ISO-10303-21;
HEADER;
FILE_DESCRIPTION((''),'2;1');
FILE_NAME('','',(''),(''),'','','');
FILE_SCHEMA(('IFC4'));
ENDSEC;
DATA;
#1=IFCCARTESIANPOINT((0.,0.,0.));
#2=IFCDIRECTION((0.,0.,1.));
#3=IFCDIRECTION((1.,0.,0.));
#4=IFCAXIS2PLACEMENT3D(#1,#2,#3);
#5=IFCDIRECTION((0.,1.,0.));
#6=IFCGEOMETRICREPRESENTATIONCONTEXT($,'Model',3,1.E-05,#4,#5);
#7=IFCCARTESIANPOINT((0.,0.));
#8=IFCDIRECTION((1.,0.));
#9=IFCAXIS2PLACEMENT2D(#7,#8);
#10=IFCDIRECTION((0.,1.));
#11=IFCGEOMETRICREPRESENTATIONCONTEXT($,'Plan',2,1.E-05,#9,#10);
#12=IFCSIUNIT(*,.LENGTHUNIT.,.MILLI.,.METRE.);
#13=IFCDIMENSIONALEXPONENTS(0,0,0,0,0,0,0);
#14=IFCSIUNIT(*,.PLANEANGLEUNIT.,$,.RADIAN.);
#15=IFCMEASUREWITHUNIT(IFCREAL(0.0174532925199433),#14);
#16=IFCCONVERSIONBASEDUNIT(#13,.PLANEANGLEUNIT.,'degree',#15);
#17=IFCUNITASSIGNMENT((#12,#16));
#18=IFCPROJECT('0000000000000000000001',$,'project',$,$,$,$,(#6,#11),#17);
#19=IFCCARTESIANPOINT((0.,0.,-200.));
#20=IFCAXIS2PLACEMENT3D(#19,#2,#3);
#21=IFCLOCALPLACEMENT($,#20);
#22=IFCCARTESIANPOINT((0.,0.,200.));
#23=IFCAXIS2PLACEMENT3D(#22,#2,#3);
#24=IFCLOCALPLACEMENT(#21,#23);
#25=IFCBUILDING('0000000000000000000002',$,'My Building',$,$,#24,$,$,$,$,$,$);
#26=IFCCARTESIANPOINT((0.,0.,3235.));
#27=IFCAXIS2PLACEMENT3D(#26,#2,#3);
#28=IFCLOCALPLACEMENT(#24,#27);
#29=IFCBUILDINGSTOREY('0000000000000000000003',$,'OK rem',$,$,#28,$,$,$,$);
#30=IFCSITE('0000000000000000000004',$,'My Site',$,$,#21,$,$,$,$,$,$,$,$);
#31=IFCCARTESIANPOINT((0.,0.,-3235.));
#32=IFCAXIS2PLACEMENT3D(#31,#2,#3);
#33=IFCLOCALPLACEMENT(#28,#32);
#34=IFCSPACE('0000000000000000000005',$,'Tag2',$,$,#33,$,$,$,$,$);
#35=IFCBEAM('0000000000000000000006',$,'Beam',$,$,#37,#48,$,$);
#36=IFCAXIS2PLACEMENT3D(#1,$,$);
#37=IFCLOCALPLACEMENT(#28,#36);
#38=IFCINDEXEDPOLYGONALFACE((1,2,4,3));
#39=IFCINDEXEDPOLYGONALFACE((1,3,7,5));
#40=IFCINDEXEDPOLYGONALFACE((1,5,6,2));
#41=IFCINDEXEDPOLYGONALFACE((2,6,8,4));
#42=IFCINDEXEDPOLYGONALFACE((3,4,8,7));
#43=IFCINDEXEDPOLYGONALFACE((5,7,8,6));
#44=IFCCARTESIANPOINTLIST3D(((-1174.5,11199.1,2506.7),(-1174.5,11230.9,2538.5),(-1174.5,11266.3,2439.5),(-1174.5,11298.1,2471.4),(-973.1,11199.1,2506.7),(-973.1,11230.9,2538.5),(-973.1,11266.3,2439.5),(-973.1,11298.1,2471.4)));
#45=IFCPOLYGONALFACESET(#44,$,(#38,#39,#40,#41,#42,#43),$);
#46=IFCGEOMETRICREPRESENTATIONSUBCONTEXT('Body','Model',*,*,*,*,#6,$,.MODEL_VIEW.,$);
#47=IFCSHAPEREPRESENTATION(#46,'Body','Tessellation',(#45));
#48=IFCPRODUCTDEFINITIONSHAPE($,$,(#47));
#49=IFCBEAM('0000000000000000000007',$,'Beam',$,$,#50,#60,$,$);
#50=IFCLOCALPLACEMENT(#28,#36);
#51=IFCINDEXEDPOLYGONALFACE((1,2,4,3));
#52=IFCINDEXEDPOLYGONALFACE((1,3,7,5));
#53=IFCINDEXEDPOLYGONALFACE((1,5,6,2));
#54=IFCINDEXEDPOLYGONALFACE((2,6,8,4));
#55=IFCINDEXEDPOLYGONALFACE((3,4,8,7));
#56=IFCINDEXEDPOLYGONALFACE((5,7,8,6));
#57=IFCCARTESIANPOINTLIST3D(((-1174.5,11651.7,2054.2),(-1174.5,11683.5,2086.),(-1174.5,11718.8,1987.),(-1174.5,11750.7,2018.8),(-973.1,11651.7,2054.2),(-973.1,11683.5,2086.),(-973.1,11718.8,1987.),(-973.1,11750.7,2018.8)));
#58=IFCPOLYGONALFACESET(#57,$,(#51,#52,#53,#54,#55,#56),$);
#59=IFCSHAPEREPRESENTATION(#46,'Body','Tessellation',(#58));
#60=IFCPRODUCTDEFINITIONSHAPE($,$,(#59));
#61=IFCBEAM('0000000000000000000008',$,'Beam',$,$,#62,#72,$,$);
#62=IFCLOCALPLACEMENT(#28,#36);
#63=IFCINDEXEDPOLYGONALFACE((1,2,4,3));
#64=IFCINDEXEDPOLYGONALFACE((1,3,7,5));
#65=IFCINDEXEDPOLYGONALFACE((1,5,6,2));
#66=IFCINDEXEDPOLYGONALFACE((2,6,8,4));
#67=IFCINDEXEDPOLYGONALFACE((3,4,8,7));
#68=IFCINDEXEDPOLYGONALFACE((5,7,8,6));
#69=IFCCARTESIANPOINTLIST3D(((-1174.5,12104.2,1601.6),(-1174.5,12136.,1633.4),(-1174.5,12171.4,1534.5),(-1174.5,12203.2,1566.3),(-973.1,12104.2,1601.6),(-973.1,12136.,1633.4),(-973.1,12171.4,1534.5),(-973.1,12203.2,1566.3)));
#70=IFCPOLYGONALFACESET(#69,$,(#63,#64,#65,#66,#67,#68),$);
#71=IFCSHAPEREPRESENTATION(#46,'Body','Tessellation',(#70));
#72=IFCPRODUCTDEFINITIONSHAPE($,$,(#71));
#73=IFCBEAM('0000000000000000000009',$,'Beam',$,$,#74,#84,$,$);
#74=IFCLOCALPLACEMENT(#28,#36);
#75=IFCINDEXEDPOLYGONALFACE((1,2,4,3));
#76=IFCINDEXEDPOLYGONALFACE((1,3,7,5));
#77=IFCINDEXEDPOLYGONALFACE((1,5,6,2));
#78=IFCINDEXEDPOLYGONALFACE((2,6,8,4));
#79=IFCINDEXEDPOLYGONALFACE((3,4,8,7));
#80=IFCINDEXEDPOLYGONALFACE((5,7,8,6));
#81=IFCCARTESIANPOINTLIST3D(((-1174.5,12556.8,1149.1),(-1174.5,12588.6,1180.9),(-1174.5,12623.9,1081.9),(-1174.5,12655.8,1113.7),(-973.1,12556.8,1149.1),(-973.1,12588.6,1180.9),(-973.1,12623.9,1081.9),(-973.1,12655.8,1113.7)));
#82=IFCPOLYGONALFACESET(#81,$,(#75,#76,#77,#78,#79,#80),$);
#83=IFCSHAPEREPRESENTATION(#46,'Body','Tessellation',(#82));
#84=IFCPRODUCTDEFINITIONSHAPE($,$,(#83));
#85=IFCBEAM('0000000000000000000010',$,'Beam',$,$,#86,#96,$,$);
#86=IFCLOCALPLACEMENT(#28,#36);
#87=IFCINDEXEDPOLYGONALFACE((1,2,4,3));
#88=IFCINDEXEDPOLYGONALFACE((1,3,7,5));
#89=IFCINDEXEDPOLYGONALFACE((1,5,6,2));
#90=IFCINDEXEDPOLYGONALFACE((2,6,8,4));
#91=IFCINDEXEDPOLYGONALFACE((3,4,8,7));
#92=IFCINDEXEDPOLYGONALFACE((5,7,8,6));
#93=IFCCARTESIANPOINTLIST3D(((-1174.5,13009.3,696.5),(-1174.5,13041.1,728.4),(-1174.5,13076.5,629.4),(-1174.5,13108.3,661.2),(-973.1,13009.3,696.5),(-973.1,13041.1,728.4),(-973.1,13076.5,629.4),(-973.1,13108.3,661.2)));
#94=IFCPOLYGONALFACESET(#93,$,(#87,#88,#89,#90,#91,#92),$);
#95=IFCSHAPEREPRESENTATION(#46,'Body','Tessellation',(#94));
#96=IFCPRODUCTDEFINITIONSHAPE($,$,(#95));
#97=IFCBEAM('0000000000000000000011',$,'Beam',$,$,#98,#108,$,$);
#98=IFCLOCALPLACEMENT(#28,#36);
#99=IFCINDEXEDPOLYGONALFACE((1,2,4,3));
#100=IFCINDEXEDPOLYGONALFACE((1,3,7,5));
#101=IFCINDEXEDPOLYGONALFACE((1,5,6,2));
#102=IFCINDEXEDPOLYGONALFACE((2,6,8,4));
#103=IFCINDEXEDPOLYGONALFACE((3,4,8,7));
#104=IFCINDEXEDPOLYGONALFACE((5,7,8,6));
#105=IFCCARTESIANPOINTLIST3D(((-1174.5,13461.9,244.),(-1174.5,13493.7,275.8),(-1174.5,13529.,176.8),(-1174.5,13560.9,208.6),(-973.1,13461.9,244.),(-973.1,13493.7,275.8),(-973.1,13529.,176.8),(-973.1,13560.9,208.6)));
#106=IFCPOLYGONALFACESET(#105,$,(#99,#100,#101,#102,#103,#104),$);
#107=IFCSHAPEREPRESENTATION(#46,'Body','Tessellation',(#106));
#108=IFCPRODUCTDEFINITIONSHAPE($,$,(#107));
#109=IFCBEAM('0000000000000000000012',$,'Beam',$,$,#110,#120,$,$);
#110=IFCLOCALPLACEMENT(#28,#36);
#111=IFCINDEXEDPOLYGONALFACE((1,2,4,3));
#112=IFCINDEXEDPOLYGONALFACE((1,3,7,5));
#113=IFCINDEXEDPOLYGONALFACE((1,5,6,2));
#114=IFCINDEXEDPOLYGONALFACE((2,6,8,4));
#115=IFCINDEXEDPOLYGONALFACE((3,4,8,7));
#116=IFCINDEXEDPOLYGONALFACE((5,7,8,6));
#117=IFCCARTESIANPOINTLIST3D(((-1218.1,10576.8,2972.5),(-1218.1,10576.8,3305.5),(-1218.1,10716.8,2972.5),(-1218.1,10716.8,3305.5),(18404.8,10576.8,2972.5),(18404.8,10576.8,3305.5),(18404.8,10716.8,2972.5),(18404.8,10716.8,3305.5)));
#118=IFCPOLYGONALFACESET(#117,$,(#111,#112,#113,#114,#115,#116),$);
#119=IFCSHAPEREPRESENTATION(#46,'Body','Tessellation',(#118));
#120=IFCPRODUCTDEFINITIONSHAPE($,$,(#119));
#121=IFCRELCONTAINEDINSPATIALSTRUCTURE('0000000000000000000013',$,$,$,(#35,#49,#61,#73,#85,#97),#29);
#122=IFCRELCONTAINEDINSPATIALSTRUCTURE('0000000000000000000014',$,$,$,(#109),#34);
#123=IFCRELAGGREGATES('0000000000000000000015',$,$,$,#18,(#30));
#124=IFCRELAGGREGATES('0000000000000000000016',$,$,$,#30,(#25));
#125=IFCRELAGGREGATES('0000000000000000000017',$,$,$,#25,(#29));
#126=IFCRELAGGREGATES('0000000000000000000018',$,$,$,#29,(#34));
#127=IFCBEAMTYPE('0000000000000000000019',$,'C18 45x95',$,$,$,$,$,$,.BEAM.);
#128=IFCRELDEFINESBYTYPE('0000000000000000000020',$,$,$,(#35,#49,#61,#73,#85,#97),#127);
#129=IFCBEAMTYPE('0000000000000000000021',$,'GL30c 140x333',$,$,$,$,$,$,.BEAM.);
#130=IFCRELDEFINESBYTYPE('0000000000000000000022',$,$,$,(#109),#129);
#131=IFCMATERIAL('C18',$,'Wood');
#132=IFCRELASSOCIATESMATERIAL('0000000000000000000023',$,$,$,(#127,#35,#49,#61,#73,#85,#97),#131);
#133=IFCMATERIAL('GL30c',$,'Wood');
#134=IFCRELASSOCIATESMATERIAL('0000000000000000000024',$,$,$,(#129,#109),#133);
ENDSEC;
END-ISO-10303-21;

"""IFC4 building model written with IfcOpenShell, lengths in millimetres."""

from ifc_helpers import new_model, entity, si_unit, converted_unit, direction, frame, origin_with_axes, origin_2d_with_axis, place, context, subcontext, project, spatial, rectangle, extrude, material, material_profile, profile_set, profile_usage, type_object, element, save


model = new_model("IFC4")

# Units and contexts
model_context = context("Model", 3, precision=1e-05, world=origin_with_axes(), true_north=direction((0.0, 1.0, 0.0)))
plan_context = context("Plan", 2, precision=1e-05, world=origin_2d_with_axis(), true_north=direction((0.0, 1.0)))
body_context = subcontext(model_context, "Body", "Model", "MODEL_VIEW")
ifc_project = project(units=[si_unit("LENGTHUNIT", "METRE", prefix="MILLI"), converted_unit("PLANEANGLEUNIT", "degree", entity("IfcReal", 0.0174532925199433), si_unit("PLANEANGLEUNIT", "RADIAN"), dimensions=[0, 0, 0, 0, 0, 0, 0])], contexts=[model_context, plan_context])

# Site, building, storey
site_placement = place(None, frame((0.0, 0.0, -200.0), z_axis=(0.0, 0.0, 1.0), x_axis=(1.0, 0.0, 0.0)))
site = spatial("IfcSite", under=ifc_project, at=site_placement, Name="My Site")
building_placement = place(site_placement, frame((0.0, 0.0, 200.0), z_axis=(0.0, 0.0, 1.0), x_axis=(1.0, 0.0, 0.0)))
building = spatial("IfcBuilding", under=site, at=building_placement, Name="My Building")
storey_placement = place(building_placement, frame((0.0, 0.0, 3235.0), z_axis=(0.0, 0.0, 1.0), x_axis=(1.0, 0.0, 0.0)))
storey = spatial("IfcBuildingStorey", under=building, at=storey_placement, Name="OK rem")

# Beams
ifc_material_1 = material(Name="C18", Category="Wood")
ifc_material_profile_1 = material_profile(ifc_material_1, rectangle(XDim=45.0, YDim=95.0))
ifc_profile_set_1 = profile_set([ifc_material_profile_1], Name="woodStructural")
beam_type_1 = type_object("IfcBeamType", Name="C18 45x95", PredefinedType="BEAM", material=ifc_profile_set_1)
ifc_profile_usage_1 = profile_usage(ifc_profile_set_1, cardinal=5)
beam_1_placement = place(storey_placement, frame((-1174.5, 11248.6, 2489.0), z_axis=(1.0, 0.0, 0.0), x_axis=(0.0, 0.707107, 0.707107)))
element("IfcBeam", 1, at=beam_1_placement, inside=storey, type_object=beam_type_1, material=ifc_profile_usage_1, Name="Beam", context=body_context, shape_type="SweptSolid", body=[
    extrude(rectangle(XDim=45.0, YDim=95.0), origin_with_axes(), (0.0, 0.0, 1.0), 201.3),
])
ifc_profile_usage_2 = profile_usage(ifc_profile_set_1, cardinal=5)
beam_2_placement = place(storey_placement, frame((-1174.5, 11701.2, 2036.5), z_axis=(1.0, 0.0, 0.0), x_axis=(0.0, 0.707107, 0.707107)))
element("IfcBeam", 2, at=beam_2_placement, inside=storey, type_object=beam_type_1, material=ifc_profile_usage_2, Name="Beam", context=body_context, shape_type="SweptSolid", body=[
    extrude(rectangle(XDim=45.0, YDim=95.0), origin_with_axes(), (0.0, 0.0, 1.0), 201.3),
])
ifc_profile_usage_3 = profile_usage(ifc_profile_set_1, cardinal=5)
beam_3_placement = place(storey_placement, frame((-1174.5, 12153.7, 1583.9), z_axis=(1.0, 0.0, 0.0), x_axis=(0.0, 0.707107, 0.707107)))
element("IfcBeam", 3, at=beam_3_placement, inside=storey, type_object=beam_type_1, material=ifc_profile_usage_3, Name="Beam", context=body_context, shape_type="SweptSolid", body=[
    extrude(rectangle(XDim=45.0, YDim=95.0), origin_with_axes(), (0.0, 0.0, 1.0), 201.3),
])
ifc_profile_usage_4 = profile_usage(ifc_profile_set_1, cardinal=5)
beam_4_placement = place(storey_placement, frame((-1174.5, 12606.3, 1131.4), z_axis=(1.0, 0.0, 0.0), x_axis=(0.0, 0.707107, 0.707107)))
element("IfcBeam", 4, at=beam_4_placement, inside=storey, type_object=beam_type_1, material=ifc_profile_usage_4, Name="Beam", context=body_context, shape_type="SweptSolid", body=[
    extrude(rectangle(XDim=45.0, YDim=95.0), origin_with_axes(), (0.0, 0.0, 1.0), 201.3),
])
ifc_profile_usage_5 = profile_usage(ifc_profile_set_1, cardinal=5)
beam_5_placement = place(storey_placement, frame((-1174.5, 13058.8, 678.9), z_axis=(1.0, 0.0, 0.0), x_axis=(0.0, 0.707107, 0.707107)))
element("IfcBeam", 5, at=beam_5_placement, inside=storey, type_object=beam_type_1, material=ifc_profile_usage_5, Name="Beam", context=body_context, shape_type="SweptSolid", body=[
    extrude(rectangle(XDim=45.0, YDim=95.0), origin_with_axes(), (0.0, 0.0, 1.0), 201.3),
])
ifc_profile_usage_6 = profile_usage(ifc_profile_set_1, cardinal=5)
beam_6_placement = place(storey_placement, frame((-1174.5, 13511.4, 226.3), z_axis=(1.0, 0.0, 0.0), x_axis=(0.0, 0.707107, 0.707107)))
element("IfcBeam", 6, at=beam_6_placement, inside=storey, type_object=beam_type_1, material=ifc_profile_usage_6, Name="Beam", context=body_context, shape_type="SweptSolid", body=[
    extrude(rectangle(XDim=45.0, YDim=95.0), origin_with_axes(), (0.0, 0.0, 1.0), 201.3),
])

# Shared definitions
space_placement = place(storey_placement, frame((0.0, 0.0, -3235.0), z_axis=(0.0, 0.0, 1.0), x_axis=(1.0, 0.0, 0.0)))
space = spatial("IfcSpace", under=storey, at=space_placement, Name="Tag2")

# Beam
ifc_material_2 = material(Name="GL30c", Category="Wood")
ifc_material_profile_2 = material_profile(ifc_material_2, rectangle(XDim=140.0, YDim=333.0))
ifc_profile_set_2 = profile_set([ifc_material_profile_2], Name="woodStructural")
ifc_profile_usage_7 = profile_usage(ifc_profile_set_2)
beam_type_2 = type_object("IfcBeamType", Name="GL30c 140x333", PredefinedType="BEAM", material=ifc_profile_set_2)
beam_7_placement = place(space_placement, frame((-1218.1, 10646.8, 6374.0), z_axis=(1.0, 0.0, 0.0), x_axis=(0.0, 1.0, 0.0)))
element("IfcBeam", 7, at=beam_7_placement, inside=space, type_object=beam_type_2, material=ifc_profile_usage_7, Name="Beam", context=body_context, shape_type="SweptSolid", body=[
    extrude(rectangle(XDim=140.0, YDim=333.0), origin_with_axes(), (0.0, 0.0, 1.0), 19622.9),
])

save(model, "model.ifc")
